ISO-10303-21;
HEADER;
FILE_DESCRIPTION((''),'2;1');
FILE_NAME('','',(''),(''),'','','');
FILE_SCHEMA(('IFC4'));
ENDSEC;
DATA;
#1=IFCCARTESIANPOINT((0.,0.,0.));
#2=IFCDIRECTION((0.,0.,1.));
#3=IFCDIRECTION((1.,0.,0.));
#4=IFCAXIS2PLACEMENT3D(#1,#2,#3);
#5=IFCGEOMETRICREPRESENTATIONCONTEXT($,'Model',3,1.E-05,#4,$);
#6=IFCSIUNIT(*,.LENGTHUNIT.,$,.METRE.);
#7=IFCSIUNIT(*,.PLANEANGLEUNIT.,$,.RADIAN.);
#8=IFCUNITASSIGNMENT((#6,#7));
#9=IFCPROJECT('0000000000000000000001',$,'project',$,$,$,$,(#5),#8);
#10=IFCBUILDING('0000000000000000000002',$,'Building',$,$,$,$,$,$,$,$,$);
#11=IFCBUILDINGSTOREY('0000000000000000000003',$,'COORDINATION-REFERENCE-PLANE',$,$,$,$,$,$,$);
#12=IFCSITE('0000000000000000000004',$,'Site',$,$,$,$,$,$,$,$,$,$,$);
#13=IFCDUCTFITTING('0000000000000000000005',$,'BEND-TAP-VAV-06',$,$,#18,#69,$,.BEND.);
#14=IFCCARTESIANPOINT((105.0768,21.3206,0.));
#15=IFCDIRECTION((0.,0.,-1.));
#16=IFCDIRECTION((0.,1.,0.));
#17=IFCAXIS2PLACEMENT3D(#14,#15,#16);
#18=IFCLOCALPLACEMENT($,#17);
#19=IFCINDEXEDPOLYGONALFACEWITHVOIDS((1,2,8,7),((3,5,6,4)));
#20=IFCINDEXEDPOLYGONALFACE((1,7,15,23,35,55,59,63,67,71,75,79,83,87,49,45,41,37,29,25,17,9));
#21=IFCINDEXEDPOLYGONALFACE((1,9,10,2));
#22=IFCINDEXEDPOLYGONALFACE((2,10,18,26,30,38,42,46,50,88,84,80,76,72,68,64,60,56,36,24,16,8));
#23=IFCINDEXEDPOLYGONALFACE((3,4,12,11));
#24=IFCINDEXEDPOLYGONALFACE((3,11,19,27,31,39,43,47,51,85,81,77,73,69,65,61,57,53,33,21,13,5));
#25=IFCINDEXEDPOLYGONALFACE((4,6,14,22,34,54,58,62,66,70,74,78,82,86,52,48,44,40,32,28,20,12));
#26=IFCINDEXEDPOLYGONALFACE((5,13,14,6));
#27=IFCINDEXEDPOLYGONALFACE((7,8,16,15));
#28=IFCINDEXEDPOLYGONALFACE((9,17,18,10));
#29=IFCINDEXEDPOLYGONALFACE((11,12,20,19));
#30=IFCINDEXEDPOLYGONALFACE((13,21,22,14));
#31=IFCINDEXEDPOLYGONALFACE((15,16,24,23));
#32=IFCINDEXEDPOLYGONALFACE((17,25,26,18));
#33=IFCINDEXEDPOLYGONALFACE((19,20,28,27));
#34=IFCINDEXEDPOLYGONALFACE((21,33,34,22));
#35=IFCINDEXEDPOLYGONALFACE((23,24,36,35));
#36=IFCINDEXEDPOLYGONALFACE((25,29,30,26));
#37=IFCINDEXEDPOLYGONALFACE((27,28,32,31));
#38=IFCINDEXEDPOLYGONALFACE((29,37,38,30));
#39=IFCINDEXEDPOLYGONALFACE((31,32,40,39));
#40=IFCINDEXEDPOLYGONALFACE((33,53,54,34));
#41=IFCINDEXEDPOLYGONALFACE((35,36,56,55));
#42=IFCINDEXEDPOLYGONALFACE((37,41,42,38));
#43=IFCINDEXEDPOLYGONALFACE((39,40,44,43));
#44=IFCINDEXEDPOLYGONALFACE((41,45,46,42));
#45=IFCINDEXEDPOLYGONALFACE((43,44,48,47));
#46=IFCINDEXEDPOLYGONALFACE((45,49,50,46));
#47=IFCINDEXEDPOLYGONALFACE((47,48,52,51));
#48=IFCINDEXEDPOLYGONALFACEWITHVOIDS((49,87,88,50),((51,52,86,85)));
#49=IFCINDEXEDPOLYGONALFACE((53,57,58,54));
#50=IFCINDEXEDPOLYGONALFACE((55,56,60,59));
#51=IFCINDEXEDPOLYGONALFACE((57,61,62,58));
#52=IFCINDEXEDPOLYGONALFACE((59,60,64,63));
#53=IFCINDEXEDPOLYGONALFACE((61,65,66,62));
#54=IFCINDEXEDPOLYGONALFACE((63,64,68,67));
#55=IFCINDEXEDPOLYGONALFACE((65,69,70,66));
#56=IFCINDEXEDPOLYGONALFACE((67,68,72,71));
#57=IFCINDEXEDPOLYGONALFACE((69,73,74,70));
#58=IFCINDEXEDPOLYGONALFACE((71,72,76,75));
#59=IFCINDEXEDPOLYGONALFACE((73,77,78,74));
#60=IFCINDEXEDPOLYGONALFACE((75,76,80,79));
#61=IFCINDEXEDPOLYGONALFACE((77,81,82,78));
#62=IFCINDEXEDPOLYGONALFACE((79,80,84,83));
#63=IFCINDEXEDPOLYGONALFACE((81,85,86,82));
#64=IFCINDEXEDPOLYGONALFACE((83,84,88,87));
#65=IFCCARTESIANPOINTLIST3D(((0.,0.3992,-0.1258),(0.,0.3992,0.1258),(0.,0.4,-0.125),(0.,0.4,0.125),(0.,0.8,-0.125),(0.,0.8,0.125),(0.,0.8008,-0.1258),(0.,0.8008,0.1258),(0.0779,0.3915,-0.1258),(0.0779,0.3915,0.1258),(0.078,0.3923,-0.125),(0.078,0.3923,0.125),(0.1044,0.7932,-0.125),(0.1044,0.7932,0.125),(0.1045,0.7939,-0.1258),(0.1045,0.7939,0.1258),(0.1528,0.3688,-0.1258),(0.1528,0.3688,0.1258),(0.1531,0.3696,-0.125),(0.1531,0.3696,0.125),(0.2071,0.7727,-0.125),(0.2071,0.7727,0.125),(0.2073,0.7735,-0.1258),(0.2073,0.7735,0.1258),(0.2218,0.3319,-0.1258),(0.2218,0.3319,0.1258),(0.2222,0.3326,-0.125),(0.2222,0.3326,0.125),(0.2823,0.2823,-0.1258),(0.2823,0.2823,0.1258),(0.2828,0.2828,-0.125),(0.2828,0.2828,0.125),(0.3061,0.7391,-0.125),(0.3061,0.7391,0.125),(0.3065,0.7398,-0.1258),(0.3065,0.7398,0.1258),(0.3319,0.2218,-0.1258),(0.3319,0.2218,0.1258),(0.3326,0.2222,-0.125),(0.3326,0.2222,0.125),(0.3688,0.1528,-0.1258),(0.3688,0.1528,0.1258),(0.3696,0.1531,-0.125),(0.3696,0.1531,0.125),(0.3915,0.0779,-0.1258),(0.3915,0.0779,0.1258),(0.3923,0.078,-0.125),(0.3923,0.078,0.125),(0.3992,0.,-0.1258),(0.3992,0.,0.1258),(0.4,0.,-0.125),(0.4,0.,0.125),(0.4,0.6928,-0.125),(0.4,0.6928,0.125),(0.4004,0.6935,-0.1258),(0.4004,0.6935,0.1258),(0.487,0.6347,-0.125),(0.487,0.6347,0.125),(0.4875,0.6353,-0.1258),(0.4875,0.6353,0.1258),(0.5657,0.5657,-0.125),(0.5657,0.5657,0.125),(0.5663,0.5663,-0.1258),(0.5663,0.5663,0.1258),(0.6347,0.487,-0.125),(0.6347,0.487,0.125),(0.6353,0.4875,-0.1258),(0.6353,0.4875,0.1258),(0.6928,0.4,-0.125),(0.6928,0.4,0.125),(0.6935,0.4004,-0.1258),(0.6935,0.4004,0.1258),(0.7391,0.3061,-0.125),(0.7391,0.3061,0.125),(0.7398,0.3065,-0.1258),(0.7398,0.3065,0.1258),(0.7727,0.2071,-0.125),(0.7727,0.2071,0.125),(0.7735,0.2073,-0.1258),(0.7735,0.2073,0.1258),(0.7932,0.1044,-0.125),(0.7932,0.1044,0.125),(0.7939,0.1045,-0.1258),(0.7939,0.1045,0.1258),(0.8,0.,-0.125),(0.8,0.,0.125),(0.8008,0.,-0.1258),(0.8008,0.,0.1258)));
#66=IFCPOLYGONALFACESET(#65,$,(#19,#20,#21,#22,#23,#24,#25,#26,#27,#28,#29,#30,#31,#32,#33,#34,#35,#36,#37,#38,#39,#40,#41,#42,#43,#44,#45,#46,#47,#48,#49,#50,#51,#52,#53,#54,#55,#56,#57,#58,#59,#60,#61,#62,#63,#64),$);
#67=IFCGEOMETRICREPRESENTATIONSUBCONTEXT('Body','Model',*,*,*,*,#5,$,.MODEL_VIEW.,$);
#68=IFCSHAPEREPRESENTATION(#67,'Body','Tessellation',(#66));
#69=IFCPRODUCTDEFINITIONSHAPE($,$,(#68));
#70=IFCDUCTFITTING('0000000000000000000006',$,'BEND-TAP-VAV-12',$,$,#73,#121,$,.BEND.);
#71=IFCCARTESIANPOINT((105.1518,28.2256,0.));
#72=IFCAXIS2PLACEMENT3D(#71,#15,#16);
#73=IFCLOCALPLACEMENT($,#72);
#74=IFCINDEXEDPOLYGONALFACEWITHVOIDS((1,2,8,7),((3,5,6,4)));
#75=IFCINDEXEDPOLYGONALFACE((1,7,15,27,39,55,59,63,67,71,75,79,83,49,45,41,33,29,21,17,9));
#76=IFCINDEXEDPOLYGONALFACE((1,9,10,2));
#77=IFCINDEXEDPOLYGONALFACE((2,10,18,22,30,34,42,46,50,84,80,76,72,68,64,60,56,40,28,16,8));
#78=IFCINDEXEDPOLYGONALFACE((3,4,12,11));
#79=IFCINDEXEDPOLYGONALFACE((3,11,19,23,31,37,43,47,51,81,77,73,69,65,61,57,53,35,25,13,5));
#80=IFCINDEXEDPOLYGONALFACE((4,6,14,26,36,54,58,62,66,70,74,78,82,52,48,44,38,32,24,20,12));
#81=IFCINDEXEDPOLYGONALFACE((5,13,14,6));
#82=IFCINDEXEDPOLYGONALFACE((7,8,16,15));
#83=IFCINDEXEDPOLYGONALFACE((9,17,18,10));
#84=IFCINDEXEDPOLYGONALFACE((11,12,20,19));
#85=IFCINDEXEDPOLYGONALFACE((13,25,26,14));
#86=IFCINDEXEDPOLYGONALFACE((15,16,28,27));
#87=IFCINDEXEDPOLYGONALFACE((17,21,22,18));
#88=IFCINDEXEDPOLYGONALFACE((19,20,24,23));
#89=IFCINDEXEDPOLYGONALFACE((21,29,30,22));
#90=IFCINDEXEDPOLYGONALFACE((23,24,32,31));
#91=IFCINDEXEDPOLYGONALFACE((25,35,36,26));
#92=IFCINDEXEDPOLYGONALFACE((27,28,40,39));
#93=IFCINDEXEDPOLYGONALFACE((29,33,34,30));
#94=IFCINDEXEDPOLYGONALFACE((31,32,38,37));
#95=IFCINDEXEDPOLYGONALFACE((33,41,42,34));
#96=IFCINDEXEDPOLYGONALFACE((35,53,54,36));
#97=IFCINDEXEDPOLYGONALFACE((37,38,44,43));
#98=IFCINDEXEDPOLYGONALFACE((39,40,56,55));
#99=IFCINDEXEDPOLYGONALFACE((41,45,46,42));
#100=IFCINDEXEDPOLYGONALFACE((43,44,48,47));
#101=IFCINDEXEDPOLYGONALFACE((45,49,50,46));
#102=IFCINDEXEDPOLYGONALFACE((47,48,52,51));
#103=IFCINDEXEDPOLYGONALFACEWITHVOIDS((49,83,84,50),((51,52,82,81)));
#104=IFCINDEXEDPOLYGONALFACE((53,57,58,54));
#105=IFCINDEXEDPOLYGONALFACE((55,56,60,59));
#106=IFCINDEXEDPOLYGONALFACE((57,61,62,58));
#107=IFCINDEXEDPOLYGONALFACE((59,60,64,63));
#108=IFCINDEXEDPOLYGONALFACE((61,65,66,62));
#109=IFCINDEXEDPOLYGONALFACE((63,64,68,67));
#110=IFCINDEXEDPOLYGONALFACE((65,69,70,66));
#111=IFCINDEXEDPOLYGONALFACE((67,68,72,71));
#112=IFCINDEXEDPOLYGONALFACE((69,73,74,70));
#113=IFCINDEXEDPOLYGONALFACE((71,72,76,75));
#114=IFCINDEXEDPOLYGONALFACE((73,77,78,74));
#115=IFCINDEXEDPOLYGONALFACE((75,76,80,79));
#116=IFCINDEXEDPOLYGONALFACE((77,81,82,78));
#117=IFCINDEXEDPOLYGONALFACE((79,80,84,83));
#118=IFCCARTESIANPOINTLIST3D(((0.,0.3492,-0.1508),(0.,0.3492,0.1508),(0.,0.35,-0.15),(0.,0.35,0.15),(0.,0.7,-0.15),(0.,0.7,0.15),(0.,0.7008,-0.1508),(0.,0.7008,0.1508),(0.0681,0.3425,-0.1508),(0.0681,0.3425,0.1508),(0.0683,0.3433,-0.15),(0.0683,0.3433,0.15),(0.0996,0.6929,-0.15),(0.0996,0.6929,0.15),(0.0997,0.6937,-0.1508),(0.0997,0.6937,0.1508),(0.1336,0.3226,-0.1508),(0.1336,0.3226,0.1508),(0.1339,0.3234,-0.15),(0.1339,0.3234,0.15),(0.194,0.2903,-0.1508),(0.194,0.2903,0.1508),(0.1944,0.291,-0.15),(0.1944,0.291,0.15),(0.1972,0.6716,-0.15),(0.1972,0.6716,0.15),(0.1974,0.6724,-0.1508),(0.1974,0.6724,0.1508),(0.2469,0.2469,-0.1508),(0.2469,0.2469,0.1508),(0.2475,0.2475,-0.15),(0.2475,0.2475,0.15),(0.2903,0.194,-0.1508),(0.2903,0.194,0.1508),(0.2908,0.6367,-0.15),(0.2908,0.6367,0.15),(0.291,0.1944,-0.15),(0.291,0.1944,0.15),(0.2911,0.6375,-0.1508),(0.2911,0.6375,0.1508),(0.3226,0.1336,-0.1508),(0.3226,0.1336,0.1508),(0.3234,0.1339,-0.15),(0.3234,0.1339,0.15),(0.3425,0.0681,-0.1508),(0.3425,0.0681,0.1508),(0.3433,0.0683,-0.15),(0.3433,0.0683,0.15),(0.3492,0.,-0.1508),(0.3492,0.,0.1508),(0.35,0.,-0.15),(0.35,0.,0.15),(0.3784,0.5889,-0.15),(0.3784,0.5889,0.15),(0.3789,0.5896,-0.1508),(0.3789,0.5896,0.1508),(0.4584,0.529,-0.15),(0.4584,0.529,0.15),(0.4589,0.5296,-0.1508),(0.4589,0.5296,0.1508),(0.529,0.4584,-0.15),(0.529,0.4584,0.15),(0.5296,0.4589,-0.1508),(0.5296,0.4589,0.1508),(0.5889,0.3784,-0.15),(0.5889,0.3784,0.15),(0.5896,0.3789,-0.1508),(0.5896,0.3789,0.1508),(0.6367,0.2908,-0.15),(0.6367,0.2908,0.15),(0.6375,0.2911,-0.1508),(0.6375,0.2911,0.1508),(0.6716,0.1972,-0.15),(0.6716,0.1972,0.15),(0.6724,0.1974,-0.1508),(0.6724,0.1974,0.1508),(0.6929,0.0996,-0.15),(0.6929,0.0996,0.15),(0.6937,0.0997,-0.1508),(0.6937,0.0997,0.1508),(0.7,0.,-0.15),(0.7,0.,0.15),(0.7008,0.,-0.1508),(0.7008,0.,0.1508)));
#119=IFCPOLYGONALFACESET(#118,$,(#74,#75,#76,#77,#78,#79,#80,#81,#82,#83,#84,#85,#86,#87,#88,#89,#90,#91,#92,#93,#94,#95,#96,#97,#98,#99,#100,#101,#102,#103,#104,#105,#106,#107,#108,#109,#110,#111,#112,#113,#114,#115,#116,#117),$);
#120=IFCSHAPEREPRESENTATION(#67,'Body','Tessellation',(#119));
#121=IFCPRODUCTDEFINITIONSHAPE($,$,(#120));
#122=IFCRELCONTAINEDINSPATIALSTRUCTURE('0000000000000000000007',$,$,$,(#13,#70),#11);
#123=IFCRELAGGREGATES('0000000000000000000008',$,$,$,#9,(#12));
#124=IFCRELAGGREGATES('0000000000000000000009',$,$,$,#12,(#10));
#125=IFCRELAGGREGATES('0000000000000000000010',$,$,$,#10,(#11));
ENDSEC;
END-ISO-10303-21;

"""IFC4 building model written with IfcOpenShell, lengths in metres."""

from ifc_helpers import new_model, entity, si_unit, frame, origin_with_axes, place, context, subcontext, project, spatial, element, save


model = new_model("IFC4")

# Units and contexts
model_context = context("Model", 3, precision=1e-05, world=origin_with_axes())
body_context_1 = subcontext(model_context, "Body", "Model", "MODEL_VIEW")
ifc_project = project(units=[si_unit("LENGTHUNIT", "METRE"), si_unit("PLANEANGLEUNIT", "RADIAN")], contexts=[model_context])

# Site, building, storey
site = spatial("IfcSite", under=ifc_project, Name="Site")
building = spatial("IfcBuilding", under=site, Name="Building")
storey = spatial("IfcBuildingStorey", under=building, Name="COORDINATION-REFERENCE-PLANE")

# Duct fittings
duct_fitting_1_placement = place(None, frame((105.0768, 21.3206, 0.0), z_axis=(0.0, 0.0, -1.0), x_axis=(0.0, 1.0, 0.0)))
cartesian_point_1 = entity("IfcCartesianPoint", [0.0, 0.0, 0.0])
element("IfcDuctFitting", 1, at=duct_fitting_1_placement, inside=storey, Name="BEND-TAP-VAV-06", PredefinedType="BEND", context=body_context_1, shape_type="SweptSolid", body=[
    entity("IfcRevolvedAreaSolid", entity("IfcRectangleHollowProfileDef", "AREA", None, entity("IfcAxis2Placement2D", entity("IfcCartesianPoint", [0.6, 0.0])), 0.4016, 0.2516, 0.0008), entity("IfcAxis2Placement3D", cartesian_point_1, entity("IfcDirection", [0.0, -1.0, 0.0]), entity("IfcDirection", [1.0, 0.0, 0.0])), entity("IfcAxis1Placement", cartesian_point_1, entity("IfcDirection", [0.0, 1.0, 0.0])), 1.570796),
])
duct_fitting_2_placement = place(None, frame((105.1518, 28.2256, 0.0), z_axis=(0.0, 0.0, -1.0), x_axis=(0.0, 1.0, 0.0)))
cartesian_point_2 = entity("IfcCartesianPoint", [0.0, 0.0, 0.0])
element("IfcDuctFitting", 2, at=duct_fitting_2_placement, inside=storey, Name="BEND-TAP-VAV-12", PredefinedType="BEND", context=body_context_1, shape_type="SweptSolid", body=[
    entity("IfcRevolvedAreaSolid", entity("IfcRectangleHollowProfileDef", "AREA", None, entity("IfcAxis2Placement2D", entity("IfcCartesianPoint", [0.525, 0.0])), 0.3516, 0.3016, 0.0008), entity("IfcAxis2Placement3D", cartesian_point_2, entity("IfcDirection", [0.0, -1.0, 0.0]), entity("IfcDirection", [1.0, 0.0, 0.0])), entity("IfcAxis1Placement", cartesian_point_2, entity("IfcDirection", [0.0, 1.0, 0.0])), 1.570796),
])

save(model, "model.ifc")
